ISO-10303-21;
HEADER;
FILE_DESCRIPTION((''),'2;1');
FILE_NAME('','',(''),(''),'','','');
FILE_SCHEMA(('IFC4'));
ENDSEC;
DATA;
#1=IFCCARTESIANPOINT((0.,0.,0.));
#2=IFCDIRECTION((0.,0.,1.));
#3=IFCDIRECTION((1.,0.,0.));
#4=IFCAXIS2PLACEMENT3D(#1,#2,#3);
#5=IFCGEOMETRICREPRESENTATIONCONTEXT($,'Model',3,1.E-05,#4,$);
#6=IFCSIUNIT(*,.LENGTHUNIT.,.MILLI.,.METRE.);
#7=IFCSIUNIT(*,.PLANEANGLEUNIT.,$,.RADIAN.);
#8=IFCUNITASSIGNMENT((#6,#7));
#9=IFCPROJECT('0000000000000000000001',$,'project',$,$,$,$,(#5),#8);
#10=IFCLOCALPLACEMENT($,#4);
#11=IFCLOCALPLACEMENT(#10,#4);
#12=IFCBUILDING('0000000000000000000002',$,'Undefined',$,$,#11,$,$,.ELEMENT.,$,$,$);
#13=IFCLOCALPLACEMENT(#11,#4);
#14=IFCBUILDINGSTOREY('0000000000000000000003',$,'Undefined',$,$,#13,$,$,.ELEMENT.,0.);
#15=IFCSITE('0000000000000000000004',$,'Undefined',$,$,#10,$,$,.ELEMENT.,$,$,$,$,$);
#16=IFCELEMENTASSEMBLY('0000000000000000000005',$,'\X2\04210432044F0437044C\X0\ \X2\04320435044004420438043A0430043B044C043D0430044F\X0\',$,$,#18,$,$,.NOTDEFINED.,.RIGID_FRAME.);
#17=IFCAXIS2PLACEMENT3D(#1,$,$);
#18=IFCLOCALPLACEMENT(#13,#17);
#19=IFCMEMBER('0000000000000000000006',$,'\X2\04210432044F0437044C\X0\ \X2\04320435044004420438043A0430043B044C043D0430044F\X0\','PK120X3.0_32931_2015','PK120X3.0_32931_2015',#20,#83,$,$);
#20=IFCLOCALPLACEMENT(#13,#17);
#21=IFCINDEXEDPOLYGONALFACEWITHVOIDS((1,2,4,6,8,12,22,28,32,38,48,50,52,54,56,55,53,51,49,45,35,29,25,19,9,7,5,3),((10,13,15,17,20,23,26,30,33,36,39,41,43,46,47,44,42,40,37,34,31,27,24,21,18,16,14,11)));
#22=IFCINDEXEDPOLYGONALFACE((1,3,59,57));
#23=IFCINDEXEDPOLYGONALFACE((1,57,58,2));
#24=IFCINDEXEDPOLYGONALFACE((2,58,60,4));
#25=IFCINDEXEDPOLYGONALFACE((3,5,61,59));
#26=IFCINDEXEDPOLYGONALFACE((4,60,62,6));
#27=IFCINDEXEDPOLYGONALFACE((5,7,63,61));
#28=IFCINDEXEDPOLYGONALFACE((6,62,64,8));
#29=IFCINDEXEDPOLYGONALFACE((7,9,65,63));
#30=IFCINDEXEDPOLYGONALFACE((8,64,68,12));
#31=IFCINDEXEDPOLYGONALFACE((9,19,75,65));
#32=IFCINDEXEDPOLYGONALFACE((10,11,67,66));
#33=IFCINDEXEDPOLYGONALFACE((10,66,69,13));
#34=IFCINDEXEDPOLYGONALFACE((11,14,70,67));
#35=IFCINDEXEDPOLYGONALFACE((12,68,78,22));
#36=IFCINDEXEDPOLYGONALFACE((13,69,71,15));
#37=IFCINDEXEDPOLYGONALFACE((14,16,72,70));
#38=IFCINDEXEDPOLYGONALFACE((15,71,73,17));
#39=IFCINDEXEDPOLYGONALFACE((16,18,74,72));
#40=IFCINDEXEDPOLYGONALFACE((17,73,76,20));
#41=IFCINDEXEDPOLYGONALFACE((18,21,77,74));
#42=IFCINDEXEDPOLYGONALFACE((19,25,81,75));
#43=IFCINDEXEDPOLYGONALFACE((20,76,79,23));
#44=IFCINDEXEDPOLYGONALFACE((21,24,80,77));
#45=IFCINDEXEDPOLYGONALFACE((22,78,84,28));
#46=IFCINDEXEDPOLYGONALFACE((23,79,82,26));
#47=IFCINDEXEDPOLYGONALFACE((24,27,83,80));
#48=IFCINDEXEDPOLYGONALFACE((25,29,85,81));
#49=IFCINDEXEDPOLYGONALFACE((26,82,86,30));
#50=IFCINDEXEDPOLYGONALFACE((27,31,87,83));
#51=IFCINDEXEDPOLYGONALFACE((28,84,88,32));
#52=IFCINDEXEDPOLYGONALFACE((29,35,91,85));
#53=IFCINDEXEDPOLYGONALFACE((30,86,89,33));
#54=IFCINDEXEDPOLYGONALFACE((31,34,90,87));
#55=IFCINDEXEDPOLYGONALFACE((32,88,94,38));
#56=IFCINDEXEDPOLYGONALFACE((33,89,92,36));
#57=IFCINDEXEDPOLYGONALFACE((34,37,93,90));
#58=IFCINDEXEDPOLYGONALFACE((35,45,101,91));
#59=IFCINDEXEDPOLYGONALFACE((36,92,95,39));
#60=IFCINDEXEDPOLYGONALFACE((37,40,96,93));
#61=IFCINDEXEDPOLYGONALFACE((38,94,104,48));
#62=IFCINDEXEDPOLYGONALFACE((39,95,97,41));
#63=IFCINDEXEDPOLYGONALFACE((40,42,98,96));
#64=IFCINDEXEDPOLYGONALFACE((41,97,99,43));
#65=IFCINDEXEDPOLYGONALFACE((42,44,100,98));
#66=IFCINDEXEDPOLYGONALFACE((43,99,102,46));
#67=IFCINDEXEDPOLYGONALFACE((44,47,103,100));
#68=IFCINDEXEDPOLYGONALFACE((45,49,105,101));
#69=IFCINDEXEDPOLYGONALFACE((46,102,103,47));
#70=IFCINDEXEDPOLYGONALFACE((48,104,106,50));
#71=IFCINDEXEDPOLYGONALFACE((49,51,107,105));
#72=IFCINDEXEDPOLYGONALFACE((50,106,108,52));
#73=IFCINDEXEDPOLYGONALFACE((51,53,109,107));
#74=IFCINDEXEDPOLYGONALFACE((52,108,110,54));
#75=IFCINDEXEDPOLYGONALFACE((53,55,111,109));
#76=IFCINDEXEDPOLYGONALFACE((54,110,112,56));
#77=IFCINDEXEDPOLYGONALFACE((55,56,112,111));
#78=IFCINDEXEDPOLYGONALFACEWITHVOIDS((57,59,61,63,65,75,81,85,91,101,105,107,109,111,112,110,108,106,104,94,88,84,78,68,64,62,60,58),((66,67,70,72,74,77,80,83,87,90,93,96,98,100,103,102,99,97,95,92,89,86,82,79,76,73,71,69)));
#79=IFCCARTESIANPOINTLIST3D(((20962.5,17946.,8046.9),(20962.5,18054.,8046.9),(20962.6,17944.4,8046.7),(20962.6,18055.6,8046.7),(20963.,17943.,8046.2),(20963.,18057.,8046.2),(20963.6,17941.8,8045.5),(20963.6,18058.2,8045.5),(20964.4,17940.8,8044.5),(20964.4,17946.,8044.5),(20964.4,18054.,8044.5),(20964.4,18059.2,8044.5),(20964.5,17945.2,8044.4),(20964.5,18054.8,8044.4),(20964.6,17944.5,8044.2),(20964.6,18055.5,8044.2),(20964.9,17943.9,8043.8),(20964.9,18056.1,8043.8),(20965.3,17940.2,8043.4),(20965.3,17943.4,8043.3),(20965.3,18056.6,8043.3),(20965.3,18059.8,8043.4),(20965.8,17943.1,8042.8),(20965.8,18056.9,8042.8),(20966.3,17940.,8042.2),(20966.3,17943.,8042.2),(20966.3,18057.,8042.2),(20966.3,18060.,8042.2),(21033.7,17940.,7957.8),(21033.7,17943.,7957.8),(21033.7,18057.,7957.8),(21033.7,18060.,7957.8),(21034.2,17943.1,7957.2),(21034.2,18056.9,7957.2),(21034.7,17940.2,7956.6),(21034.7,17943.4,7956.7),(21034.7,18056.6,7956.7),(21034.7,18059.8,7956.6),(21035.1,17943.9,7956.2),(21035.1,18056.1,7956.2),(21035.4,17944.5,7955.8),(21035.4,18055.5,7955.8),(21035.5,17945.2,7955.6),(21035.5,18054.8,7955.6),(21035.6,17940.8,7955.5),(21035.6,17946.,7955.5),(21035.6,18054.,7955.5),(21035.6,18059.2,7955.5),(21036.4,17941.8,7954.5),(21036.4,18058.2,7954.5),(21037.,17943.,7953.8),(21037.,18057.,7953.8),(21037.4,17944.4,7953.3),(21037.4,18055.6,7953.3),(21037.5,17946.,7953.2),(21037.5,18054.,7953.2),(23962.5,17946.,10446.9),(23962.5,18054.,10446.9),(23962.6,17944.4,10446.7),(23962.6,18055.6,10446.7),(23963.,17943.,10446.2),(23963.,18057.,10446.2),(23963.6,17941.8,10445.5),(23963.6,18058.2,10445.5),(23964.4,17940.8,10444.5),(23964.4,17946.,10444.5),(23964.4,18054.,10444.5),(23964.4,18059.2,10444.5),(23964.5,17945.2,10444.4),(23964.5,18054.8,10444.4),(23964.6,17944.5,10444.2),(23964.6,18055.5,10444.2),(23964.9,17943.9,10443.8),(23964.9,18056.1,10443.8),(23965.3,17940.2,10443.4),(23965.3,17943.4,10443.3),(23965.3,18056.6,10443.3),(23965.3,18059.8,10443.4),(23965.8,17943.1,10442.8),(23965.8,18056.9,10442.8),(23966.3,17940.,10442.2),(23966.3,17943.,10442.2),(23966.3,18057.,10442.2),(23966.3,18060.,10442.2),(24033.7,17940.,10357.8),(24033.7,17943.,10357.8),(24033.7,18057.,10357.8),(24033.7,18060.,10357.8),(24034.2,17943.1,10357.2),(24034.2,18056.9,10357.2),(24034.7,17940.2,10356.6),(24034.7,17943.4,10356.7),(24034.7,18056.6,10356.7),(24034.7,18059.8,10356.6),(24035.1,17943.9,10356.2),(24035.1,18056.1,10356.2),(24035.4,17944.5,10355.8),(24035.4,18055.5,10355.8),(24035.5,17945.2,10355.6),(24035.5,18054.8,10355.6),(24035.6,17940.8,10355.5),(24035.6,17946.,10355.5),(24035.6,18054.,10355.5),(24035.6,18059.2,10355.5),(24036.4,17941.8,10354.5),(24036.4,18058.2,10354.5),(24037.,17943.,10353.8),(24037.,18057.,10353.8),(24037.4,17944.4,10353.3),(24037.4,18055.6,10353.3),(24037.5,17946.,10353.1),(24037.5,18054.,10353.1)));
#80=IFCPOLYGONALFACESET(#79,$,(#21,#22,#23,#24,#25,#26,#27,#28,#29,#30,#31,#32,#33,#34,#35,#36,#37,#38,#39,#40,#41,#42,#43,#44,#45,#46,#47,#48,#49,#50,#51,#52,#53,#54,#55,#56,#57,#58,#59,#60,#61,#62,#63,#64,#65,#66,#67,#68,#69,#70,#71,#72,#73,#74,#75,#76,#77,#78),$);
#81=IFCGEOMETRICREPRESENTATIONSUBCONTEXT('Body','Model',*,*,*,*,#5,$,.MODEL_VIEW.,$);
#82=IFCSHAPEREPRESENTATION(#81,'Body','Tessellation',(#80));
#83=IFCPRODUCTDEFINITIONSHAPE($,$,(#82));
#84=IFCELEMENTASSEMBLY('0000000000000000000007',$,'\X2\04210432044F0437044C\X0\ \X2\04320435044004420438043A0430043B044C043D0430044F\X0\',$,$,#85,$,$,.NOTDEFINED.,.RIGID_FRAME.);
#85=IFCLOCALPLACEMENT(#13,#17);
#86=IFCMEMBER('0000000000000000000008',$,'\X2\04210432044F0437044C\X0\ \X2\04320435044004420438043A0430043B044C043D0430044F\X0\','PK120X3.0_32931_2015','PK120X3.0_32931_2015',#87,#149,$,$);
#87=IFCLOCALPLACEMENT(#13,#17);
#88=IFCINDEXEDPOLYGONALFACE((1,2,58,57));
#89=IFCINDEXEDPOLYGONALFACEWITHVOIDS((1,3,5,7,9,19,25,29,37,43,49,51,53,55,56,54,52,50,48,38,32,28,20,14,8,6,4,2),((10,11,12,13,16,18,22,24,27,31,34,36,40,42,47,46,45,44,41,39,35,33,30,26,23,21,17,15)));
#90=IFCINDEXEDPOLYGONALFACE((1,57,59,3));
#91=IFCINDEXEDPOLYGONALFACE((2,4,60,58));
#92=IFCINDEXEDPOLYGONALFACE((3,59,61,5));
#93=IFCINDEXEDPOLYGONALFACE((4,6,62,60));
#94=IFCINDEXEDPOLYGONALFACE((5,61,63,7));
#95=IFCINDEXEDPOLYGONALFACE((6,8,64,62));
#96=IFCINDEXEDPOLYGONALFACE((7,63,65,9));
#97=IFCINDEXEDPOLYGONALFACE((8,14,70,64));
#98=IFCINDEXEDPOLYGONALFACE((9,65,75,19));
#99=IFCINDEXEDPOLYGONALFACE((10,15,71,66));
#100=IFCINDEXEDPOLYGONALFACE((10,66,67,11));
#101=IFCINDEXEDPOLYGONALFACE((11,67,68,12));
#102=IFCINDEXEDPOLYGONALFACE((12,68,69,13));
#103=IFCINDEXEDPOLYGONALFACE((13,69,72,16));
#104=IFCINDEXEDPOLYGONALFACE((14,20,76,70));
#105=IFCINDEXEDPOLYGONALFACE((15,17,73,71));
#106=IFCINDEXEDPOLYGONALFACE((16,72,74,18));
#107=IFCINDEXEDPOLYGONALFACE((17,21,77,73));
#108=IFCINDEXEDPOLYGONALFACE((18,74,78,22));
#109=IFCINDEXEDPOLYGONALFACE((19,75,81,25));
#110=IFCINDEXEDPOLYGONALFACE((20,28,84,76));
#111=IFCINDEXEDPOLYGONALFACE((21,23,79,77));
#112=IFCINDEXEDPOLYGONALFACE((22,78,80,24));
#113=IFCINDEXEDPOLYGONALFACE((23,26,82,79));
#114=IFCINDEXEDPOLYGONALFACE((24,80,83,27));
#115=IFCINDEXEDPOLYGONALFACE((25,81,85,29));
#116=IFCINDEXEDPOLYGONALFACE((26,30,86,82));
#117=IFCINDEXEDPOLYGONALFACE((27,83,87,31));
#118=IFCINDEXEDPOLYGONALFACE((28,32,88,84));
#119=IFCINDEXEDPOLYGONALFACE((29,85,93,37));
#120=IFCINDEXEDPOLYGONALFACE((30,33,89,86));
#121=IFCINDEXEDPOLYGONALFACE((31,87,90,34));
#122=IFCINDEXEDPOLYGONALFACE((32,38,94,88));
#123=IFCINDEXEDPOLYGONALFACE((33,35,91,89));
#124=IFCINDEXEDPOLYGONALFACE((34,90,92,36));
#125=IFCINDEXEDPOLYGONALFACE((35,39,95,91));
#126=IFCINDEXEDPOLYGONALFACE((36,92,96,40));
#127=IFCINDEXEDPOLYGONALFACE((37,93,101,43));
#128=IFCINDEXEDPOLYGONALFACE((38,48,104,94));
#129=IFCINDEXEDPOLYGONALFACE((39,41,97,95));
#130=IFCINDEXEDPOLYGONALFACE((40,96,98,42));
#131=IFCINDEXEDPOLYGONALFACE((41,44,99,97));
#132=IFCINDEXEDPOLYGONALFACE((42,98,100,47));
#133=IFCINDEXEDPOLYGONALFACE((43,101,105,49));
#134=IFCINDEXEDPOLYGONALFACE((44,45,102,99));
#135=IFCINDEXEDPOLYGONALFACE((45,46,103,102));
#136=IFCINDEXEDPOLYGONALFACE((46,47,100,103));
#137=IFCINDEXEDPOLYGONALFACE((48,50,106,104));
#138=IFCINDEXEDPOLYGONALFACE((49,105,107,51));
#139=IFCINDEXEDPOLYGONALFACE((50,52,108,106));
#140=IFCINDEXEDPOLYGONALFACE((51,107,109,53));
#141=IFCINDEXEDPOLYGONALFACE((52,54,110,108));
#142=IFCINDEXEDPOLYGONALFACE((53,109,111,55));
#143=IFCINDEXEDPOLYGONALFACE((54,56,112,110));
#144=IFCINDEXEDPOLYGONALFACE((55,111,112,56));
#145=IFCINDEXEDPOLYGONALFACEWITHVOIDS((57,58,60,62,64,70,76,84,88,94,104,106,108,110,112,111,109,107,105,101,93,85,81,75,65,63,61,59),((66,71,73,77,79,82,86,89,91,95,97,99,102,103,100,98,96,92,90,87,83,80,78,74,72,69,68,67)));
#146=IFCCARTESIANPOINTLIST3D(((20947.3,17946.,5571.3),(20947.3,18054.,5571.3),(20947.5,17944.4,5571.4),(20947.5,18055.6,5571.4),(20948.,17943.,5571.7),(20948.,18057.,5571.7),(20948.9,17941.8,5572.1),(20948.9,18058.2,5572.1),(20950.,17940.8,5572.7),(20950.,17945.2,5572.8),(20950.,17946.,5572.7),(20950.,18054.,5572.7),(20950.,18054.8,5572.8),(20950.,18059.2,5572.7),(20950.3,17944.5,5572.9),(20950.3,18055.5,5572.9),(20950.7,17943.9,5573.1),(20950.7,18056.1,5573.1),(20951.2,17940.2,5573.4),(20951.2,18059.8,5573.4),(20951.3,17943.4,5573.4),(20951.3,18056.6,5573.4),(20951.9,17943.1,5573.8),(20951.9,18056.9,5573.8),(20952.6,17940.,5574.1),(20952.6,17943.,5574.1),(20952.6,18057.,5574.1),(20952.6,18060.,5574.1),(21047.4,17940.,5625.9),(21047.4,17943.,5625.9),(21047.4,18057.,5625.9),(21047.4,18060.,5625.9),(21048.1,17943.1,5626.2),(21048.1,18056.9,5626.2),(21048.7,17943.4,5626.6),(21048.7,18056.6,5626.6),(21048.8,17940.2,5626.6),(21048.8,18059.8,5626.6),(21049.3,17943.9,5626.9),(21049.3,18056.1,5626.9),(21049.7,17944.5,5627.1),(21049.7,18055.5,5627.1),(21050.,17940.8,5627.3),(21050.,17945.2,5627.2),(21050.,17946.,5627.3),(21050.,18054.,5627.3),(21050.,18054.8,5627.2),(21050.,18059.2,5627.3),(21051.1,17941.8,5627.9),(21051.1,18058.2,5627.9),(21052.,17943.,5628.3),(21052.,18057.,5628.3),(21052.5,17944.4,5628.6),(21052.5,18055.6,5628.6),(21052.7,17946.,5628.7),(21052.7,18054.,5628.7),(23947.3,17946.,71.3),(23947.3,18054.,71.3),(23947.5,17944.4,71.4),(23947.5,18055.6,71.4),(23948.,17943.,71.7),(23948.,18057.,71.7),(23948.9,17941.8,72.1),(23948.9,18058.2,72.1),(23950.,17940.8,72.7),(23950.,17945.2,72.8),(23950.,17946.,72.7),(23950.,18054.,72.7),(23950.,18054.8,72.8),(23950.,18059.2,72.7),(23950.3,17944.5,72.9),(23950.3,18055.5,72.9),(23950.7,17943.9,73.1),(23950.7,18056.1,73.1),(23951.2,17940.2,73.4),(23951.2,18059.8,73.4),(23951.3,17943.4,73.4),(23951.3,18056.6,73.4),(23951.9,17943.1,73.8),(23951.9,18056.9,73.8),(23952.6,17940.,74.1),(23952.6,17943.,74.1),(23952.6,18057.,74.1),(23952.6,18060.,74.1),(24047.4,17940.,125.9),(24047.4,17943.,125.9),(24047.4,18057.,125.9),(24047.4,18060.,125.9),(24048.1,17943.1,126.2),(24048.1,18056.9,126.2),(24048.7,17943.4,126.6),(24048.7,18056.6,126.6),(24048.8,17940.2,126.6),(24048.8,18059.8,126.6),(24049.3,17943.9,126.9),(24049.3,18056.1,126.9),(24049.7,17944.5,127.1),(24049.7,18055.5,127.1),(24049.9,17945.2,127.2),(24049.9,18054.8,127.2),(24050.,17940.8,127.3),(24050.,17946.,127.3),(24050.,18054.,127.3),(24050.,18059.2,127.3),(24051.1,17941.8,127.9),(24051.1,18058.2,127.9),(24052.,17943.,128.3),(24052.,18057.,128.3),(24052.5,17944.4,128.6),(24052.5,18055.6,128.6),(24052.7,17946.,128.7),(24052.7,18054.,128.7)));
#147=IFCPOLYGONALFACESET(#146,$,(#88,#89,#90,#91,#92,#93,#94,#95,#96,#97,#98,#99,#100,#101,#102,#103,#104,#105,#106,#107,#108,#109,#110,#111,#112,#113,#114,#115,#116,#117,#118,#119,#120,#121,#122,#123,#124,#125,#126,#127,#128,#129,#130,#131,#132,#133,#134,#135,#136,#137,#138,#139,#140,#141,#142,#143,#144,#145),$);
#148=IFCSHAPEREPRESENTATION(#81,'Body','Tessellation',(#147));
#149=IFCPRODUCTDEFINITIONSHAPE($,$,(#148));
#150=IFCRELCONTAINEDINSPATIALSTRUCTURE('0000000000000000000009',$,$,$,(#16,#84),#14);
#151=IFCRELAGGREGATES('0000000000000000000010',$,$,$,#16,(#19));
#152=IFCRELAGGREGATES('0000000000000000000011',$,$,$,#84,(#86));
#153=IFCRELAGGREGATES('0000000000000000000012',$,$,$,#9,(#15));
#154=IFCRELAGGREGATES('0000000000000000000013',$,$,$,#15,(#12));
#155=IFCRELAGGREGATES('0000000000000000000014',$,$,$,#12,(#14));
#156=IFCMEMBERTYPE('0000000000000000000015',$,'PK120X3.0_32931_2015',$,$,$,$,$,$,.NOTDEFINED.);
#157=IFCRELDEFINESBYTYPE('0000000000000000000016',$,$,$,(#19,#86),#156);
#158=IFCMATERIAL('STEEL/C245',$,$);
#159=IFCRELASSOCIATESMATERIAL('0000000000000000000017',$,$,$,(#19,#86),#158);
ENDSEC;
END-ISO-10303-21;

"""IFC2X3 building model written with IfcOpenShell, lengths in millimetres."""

from ifc_helpers import new_model, si_unit, frame, origin_with_axes, origin_2d_with_axis, place, context, subcontext, project, spatial, hollow_rectangle, extrude, material, type_object, element, aggregate, save


model = new_model("IFC2X3")

# Units and contexts
model_context = context("Model", 3, precision=1e-05, world=origin_with_axes())
body_context = subcontext(model_context, "Body", "Model", "MODEL_VIEW")
ifc_project = project(units=[si_unit("LENGTHUNIT", "METRE", prefix="MILLI"), si_unit("PLANEANGLEUNIT", "RADIAN")], contexts=[model_context])

# Site, building, storey
site_placement = place(None, origin_with_axes())
site = spatial("IfcSite", under=ifc_project, at=site_placement, Name="Undefined", CompositionType="ELEMENT")
building_placement = place(site_placement, origin_with_axes())
building = spatial("IfcBuilding", under=site, at=building_placement, Name="Undefined", CompositionType="ELEMENT")
storey_placement = place(building_placement, origin_with_axes())
storey = spatial("IfcBuildingStorey", under=building, at=storey_placement, Name="Undefined", CompositionType="ELEMENT", Elevation=0.0)

# Shared definitions
ifc_material_1 = material(Name="STEEL/C245")

# Element assemblies, members
member_type_1 = type_object("IfcMemberType", Name="PK120X3.0_32931_2015", PredefinedType="NOTDEFINED")
assembly_1_placement = place(storey_placement, origin_with_axes())
assembly_1 = element("IfcElementAssembly", 1, at=assembly_1_placement, inside=storey, Name="Связь вертикальная", AssemblyPlace="NOTDEFINED", PredefinedType="RIGID_FRAME")
member_1_placement = place(assembly_1_placement, frame((21000.0, 18000.0, 8000.0), z_axis=(-0.624695, 0.0, 0.780869), x_axis=(0.780869, 0.0, 0.624695)))
member_1 = element("IfcMember", 2, at=member_1_placement, type_object=member_type_1, material=ifc_material_1, Name="Связь вертикальная", Description="PK120X3.0_32931_2015", ObjectType="PK120X3.0_32931_2015", context=body_context, shape_type="SweptSolid", body=[
    extrude(hollow_rectangle(XDim=120.0, YDim=120.0, WallThickness=3.0, InnerFilletRadius=3.0, OuterFilletRadius=6.0, at=origin_2d_with_axis()), frame((3841.9, 0.0, 0.0), z_axis=(-1.0, 0.0, 0.0), x_axis=(0.0, -1.0, 0.0)), (0.0, 0.0, 1.0), 3841.9),
])
aggregate(assembly_1, [member_1])
assembly_2_placement = place(storey_placement, origin_with_axes())
assembly_2 = element("IfcElementAssembly", 3, at=assembly_2_placement, inside=storey, Name="Связь вертикальная", AssemblyPlace="NOTDEFINED", PredefinedType="RIGID_FRAME")
member_2_placement = place(assembly_2_placement, frame((24000.0, 18000.0, 100.0), z_axis=(0.877896, 0.0, 0.478852), x_axis=(-0.478852, 0.0, 0.877896)))
member_2 = element("IfcMember", 4, at=member_2_placement, type_object=member_type_1, material=ifc_material_1, Name="Связь вертикальная", Description="PK120X3.0_32931_2015", ObjectType="PK120X3.0_32931_2015", context=body_context, shape_type="SweptSolid", body=[
    extrude(hollow_rectangle(XDim=120.0, YDim=120.0, WallThickness=3.0, InnerFilletRadius=3.0, OuterFilletRadius=6.0, at=origin_2d_with_axis()), frame((6265.0, 0.0, 0.0), z_axis=(-1.0, 0.0, 0.0), x_axis=(0.0, -1.0, 0.0)), (0.0, 0.0, 1.0), 6265.0),
])
aggregate(assembly_2, [member_2])

save(model, "model.ifc")
